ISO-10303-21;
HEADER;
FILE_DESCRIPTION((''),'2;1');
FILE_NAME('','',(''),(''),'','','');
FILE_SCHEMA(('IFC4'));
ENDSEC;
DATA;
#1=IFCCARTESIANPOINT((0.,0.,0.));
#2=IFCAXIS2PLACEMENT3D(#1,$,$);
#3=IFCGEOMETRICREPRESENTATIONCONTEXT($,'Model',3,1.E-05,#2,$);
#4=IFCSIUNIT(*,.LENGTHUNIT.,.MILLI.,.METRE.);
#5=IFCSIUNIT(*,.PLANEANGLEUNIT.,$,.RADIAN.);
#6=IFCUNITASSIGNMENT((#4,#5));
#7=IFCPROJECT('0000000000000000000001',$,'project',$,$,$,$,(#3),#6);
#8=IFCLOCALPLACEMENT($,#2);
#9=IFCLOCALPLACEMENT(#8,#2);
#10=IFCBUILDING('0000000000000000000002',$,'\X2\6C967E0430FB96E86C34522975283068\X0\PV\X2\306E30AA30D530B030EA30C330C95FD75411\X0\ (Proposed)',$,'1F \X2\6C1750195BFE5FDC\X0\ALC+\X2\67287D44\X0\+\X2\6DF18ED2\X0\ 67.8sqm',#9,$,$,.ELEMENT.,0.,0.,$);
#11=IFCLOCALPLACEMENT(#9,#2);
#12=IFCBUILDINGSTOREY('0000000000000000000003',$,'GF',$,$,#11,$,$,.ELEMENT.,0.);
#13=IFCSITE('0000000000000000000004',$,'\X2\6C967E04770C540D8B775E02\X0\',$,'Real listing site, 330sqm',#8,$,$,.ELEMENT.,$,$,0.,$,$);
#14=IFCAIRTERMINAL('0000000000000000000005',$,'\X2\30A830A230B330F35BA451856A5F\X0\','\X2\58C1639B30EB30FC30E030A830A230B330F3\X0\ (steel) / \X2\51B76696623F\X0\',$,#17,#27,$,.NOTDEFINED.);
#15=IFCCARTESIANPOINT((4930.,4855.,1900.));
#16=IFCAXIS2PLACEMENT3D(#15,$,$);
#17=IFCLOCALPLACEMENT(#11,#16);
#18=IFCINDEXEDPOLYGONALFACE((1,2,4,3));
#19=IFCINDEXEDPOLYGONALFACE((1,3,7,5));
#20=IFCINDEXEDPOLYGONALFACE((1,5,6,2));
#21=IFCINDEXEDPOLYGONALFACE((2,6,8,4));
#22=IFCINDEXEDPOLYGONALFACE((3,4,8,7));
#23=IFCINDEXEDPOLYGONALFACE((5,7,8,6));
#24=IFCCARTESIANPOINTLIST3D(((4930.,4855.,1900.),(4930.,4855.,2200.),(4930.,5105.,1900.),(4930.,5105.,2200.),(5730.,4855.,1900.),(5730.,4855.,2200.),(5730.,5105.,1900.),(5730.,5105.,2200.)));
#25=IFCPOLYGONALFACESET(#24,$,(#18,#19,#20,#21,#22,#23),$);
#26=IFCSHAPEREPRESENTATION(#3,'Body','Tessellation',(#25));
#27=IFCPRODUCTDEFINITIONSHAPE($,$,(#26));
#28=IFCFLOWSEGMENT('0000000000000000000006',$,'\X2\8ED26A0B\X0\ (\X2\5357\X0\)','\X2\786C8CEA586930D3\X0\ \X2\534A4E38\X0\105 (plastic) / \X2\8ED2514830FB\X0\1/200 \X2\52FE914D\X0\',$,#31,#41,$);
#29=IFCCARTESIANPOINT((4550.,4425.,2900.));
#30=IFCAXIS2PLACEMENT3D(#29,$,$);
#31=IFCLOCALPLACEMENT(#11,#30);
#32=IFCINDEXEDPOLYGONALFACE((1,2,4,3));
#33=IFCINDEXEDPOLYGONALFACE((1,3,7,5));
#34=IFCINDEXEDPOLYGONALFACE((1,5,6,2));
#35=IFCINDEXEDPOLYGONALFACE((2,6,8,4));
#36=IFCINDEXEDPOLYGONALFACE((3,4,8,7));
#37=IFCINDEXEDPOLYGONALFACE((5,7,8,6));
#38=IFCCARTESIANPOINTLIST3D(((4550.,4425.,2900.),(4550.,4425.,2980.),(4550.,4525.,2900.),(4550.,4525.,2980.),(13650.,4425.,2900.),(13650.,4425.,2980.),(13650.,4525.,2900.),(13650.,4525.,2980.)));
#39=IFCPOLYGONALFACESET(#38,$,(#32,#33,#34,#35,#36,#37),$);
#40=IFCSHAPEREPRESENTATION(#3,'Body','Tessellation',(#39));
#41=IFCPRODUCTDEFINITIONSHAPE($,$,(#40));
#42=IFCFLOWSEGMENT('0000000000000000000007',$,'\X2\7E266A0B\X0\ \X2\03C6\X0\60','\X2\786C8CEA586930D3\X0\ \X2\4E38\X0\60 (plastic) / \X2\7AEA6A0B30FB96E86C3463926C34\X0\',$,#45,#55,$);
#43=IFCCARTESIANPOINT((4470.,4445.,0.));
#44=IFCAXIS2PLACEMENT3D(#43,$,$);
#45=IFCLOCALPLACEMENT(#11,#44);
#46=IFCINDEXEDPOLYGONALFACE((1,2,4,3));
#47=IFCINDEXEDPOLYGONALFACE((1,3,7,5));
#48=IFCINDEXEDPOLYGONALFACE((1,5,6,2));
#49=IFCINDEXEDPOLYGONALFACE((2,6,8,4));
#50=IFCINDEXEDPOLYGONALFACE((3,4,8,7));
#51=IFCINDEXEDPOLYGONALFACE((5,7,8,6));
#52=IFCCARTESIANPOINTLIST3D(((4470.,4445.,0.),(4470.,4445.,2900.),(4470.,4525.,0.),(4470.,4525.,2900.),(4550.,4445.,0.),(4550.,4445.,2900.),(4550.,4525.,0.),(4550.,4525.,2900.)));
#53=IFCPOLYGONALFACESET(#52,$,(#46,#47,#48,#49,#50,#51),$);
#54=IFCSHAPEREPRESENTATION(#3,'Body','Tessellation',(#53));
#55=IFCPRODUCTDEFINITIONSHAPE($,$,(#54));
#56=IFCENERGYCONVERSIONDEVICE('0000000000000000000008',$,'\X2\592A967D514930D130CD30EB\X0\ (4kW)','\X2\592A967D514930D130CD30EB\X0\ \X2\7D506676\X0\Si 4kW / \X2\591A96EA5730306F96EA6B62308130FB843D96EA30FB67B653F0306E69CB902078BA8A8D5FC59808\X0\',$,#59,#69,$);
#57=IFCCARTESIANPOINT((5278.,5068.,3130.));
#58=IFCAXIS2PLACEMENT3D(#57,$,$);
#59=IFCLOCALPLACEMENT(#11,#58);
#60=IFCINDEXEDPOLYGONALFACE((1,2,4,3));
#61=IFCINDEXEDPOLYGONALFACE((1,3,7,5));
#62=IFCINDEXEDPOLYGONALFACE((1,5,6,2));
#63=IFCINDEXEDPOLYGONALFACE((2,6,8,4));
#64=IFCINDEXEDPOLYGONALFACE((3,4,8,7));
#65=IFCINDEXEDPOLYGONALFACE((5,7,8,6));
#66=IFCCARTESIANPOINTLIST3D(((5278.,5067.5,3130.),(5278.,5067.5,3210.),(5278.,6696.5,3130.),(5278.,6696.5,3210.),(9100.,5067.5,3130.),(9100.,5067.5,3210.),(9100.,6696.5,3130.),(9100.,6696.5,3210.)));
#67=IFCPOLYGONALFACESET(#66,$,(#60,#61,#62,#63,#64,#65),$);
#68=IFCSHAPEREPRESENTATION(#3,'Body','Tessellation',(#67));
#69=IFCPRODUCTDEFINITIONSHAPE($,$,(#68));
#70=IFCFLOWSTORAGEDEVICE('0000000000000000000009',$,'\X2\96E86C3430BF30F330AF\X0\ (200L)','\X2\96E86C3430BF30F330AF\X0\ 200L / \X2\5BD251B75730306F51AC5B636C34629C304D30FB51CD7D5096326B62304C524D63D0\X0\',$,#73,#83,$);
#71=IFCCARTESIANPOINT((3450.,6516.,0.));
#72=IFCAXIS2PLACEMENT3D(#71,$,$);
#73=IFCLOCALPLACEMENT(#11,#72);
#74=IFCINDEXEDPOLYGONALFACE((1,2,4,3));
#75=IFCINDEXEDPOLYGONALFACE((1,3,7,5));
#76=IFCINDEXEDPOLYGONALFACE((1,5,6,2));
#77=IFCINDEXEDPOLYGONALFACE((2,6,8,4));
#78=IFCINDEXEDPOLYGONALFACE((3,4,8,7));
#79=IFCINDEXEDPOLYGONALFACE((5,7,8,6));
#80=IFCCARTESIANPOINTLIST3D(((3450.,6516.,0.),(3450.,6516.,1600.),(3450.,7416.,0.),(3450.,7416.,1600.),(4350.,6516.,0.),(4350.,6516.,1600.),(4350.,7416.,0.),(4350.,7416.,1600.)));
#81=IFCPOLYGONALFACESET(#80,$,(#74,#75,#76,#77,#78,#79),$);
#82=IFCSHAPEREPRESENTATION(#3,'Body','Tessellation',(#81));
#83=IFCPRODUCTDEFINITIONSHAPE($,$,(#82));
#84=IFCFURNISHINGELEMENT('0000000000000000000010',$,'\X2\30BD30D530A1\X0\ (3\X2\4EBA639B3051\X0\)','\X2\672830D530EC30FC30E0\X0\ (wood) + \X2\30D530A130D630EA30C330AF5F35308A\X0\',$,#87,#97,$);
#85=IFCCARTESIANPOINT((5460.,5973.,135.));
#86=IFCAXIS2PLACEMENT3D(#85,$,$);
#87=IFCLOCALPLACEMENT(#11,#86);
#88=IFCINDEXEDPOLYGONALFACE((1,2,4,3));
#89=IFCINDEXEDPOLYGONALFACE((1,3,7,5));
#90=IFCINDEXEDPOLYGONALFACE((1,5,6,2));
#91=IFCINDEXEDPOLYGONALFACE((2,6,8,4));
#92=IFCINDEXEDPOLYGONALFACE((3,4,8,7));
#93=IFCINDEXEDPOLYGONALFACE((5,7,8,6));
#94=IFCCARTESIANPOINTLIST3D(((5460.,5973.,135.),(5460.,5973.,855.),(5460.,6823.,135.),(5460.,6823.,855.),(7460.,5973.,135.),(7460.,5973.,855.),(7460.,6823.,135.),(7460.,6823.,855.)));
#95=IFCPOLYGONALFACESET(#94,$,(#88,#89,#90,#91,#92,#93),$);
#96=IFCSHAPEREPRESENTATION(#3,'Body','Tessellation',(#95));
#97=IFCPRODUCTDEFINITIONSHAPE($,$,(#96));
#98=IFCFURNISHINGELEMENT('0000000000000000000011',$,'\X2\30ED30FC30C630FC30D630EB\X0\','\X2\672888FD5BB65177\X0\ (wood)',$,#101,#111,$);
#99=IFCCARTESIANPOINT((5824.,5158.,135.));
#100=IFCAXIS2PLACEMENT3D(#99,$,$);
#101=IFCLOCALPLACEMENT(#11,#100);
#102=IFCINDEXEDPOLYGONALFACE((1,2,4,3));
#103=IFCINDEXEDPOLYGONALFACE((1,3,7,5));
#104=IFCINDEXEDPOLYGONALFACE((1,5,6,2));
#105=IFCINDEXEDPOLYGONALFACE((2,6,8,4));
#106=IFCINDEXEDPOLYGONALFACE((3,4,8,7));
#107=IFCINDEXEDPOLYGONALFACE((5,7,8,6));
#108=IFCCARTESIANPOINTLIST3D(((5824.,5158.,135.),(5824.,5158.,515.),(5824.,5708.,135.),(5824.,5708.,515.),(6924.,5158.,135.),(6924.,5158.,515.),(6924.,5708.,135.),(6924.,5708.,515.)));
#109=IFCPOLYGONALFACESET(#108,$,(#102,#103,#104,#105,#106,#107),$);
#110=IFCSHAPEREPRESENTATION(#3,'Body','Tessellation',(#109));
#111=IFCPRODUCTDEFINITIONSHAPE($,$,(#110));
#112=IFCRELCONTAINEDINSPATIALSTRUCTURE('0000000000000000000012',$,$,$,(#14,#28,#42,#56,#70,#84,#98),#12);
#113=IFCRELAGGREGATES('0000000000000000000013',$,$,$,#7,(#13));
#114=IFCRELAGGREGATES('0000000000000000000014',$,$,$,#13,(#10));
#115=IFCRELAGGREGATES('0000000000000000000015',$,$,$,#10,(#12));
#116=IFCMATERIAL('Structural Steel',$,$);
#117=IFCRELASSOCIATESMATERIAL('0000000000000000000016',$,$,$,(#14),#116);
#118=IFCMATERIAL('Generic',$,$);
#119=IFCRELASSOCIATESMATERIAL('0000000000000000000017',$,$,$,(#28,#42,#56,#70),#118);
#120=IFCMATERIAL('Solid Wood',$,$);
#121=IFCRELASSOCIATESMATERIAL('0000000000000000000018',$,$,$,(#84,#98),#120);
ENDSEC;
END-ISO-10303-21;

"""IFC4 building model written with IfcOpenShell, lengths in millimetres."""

from ifc_helpers import new_model, si_unit, frame, frame_2d, origin, place, context, project, spatial, rectangle, extrude, material, element, save


model = new_model("IFC4")

# Units and contexts
model_context = context("Model", 3, precision=1e-05, world=origin())
ifc_project = project(units=[si_unit("LENGTHUNIT", "METRE", prefix="MILLI"), si_unit("PLANEANGLEUNIT", "RADIAN")], contexts=[model_context])

# Site, building, storey
site_placement = place(None, origin())
site = spatial("IfcSite", under=ifc_project, at=site_placement, Name="沖縄県名護市", ObjectType="Real listing site, 330sqm", CompositionType="ELEMENT", RefElevation=0.0)
building_placement = place(site_placement, origin())
building = spatial("IfcBuilding", under=site, at=building_placement, Name="沖縄・雨水利用とPVのオフグリッド志向 (Proposed)", ObjectType="1F 気候対応ALC+木組+深軒 67.8sqm", CompositionType="ELEMENT", ElevationOfRefHeight=0.0, ElevationOfTerrain=0.0)
storey_placement = place(building_placement, origin())
storey = spatial("IfcBuildingStorey", under=building, at=storey_placement, Name="GF", CompositionType="ELEMENT", Elevation=0.0)

# Shared definitions
ifc_material_1 = material(Name="Solid Wood")

# Shared definitions
ifc_material_2 = material(Name="Structural Steel")

# Shared definitions
ifc_material_3 = material(Name="Generic")

# Air terminal
air_terminal_placement = place(storey_placement, frame((4930.0, 4855.0, 1900.0)))
element("IfcAirTerminal", 1, at=air_terminal_placement, inside=storey, material=ifc_material_2, Name="エアコン室内機", Description="壁掛ルームエアコン (steel) / 冷暖房", PredefinedType="NOTDEFINED", context=model_context, shape_type="SweptSolid", body=[
    extrude(rectangle(XDim=800.0, YDim=250.0, at=frame_2d((400.0, 125.0))), frame((4930.0, 4855.0, 1900.0)), (0.0, 0.0, 1.0), 300.0),
])

# Flow segments
flow_segment_1_placement = place(storey_placement, frame((4550.0, 4425.0, 2900.0)))
element("IfcFlowSegment", 2, at=flow_segment_1_placement, inside=storey, material=ifc_material_3, Name="軒樋 (南)", Description="硬質塩ビ 半丸105 (plastic) / 軒先・1/200 勾配", context=model_context, shape_type="SweptSolid", body=[
    extrude(rectangle(XDim=9100.0, YDim=100.0, at=frame_2d((4550.0, 50.0))), frame((4550.0, 4425.0, 2900.0)), (0.0, 0.0, 1.0), 80.0),
])
flow_segment_2_placement = place(storey_placement, frame((4470.0, 4445.0, 0.0)))
element("IfcFlowSegment", 3, at=flow_segment_2_placement, inside=storey, material=ifc_material_3, Name="縦樋 φ60", Description="硬質塩ビ 丸60 (plastic) / 竪樋・雨水排水", context=model_context, shape_type="SweptSolid", body=[
    extrude(rectangle(XDim=80.0, YDim=80.0, at=frame_2d((40.0, 40.0))), frame((4470.0, 4445.0, 0.0)), (0.0, 0.0, 1.0), 2900.0),
])

# Energy conversion device
energy_conversion_device_placement = place(storey_placement, frame((5278.0, 5068.0, 3130.0)))
element("IfcEnergyConversionDevice", 4, at=energy_conversion_device_placement, inside=storey, material=ifc_material_3, Name="太陽光パネル (4kW)", Description="太陽光パネル 結晶Si 4kW / 多雪地は雪止め・落雪・架台の構造確認必須", context=model_context, shape_type="SweptSolid", body=[
    extrude(rectangle(XDim=3822.0, YDim=1629.0, at=frame_2d((1911.0, 814.0))), frame((5278.0, 5068.0, 3130.0)), (0.0, 0.0, 1.0), 80.0),
])

# Flow storage device
flow_storage_device_placement = place(storey_placement, frame((3450.0, 6516.0, 0.0)))
element("IfcFlowStorageDevice", 5, at=flow_storage_device_placement, inside=storey, material=ifc_material_3, Name="雨水タンク (200L)", Description="雨水タンク 200L / 寒冷地は冬季水抜き・凍結防止が前提", context=model_context, shape_type="SweptSolid", body=[
    extrude(rectangle(XDim=900.0, YDim=900.0, at=frame_2d((450.0, 450.0))), frame((3450.0, 6516.0, 0.0)), (0.0, 0.0, 1.0), 1600.0),
])

# Furnishing elements
furnishing_1_placement = place(storey_placement, frame((5460.0, 5973.0, 135.0)))
element("IfcFurnishingElement", 6, at=furnishing_1_placement, inside=storey, material=ifc_material_1, Name="ソファ (3人掛け)", Description="木フレーム (wood) + ファブリック張り", context=model_context, shape_type="SweptSolid", body=[
    extrude(rectangle(XDim=2000.0, YDim=850.0, at=frame_2d((1000.0, 425.0))), frame((5460.0, 5973.0, 135.0)), (0.0, 0.0, 1.0), 720.0),
])
furnishing_2_placement = place(storey_placement, frame((5824.0, 5158.0, 135.0)))
element("IfcFurnishingElement", 7, at=furnishing_2_placement, inside=storey, material=ifc_material_1, Name="ローテーブル", Description="木製家具 (wood)", context=model_context, shape_type="SweptSolid", body=[
    extrude(rectangle(XDim=1100.0, YDim=550.0, at=frame_2d((550.0, 275.0))), frame((5824.0, 5158.0, 135.0)), (0.0, 0.0, 1.0), 380.0),
])

save(model, "model.ifc")
